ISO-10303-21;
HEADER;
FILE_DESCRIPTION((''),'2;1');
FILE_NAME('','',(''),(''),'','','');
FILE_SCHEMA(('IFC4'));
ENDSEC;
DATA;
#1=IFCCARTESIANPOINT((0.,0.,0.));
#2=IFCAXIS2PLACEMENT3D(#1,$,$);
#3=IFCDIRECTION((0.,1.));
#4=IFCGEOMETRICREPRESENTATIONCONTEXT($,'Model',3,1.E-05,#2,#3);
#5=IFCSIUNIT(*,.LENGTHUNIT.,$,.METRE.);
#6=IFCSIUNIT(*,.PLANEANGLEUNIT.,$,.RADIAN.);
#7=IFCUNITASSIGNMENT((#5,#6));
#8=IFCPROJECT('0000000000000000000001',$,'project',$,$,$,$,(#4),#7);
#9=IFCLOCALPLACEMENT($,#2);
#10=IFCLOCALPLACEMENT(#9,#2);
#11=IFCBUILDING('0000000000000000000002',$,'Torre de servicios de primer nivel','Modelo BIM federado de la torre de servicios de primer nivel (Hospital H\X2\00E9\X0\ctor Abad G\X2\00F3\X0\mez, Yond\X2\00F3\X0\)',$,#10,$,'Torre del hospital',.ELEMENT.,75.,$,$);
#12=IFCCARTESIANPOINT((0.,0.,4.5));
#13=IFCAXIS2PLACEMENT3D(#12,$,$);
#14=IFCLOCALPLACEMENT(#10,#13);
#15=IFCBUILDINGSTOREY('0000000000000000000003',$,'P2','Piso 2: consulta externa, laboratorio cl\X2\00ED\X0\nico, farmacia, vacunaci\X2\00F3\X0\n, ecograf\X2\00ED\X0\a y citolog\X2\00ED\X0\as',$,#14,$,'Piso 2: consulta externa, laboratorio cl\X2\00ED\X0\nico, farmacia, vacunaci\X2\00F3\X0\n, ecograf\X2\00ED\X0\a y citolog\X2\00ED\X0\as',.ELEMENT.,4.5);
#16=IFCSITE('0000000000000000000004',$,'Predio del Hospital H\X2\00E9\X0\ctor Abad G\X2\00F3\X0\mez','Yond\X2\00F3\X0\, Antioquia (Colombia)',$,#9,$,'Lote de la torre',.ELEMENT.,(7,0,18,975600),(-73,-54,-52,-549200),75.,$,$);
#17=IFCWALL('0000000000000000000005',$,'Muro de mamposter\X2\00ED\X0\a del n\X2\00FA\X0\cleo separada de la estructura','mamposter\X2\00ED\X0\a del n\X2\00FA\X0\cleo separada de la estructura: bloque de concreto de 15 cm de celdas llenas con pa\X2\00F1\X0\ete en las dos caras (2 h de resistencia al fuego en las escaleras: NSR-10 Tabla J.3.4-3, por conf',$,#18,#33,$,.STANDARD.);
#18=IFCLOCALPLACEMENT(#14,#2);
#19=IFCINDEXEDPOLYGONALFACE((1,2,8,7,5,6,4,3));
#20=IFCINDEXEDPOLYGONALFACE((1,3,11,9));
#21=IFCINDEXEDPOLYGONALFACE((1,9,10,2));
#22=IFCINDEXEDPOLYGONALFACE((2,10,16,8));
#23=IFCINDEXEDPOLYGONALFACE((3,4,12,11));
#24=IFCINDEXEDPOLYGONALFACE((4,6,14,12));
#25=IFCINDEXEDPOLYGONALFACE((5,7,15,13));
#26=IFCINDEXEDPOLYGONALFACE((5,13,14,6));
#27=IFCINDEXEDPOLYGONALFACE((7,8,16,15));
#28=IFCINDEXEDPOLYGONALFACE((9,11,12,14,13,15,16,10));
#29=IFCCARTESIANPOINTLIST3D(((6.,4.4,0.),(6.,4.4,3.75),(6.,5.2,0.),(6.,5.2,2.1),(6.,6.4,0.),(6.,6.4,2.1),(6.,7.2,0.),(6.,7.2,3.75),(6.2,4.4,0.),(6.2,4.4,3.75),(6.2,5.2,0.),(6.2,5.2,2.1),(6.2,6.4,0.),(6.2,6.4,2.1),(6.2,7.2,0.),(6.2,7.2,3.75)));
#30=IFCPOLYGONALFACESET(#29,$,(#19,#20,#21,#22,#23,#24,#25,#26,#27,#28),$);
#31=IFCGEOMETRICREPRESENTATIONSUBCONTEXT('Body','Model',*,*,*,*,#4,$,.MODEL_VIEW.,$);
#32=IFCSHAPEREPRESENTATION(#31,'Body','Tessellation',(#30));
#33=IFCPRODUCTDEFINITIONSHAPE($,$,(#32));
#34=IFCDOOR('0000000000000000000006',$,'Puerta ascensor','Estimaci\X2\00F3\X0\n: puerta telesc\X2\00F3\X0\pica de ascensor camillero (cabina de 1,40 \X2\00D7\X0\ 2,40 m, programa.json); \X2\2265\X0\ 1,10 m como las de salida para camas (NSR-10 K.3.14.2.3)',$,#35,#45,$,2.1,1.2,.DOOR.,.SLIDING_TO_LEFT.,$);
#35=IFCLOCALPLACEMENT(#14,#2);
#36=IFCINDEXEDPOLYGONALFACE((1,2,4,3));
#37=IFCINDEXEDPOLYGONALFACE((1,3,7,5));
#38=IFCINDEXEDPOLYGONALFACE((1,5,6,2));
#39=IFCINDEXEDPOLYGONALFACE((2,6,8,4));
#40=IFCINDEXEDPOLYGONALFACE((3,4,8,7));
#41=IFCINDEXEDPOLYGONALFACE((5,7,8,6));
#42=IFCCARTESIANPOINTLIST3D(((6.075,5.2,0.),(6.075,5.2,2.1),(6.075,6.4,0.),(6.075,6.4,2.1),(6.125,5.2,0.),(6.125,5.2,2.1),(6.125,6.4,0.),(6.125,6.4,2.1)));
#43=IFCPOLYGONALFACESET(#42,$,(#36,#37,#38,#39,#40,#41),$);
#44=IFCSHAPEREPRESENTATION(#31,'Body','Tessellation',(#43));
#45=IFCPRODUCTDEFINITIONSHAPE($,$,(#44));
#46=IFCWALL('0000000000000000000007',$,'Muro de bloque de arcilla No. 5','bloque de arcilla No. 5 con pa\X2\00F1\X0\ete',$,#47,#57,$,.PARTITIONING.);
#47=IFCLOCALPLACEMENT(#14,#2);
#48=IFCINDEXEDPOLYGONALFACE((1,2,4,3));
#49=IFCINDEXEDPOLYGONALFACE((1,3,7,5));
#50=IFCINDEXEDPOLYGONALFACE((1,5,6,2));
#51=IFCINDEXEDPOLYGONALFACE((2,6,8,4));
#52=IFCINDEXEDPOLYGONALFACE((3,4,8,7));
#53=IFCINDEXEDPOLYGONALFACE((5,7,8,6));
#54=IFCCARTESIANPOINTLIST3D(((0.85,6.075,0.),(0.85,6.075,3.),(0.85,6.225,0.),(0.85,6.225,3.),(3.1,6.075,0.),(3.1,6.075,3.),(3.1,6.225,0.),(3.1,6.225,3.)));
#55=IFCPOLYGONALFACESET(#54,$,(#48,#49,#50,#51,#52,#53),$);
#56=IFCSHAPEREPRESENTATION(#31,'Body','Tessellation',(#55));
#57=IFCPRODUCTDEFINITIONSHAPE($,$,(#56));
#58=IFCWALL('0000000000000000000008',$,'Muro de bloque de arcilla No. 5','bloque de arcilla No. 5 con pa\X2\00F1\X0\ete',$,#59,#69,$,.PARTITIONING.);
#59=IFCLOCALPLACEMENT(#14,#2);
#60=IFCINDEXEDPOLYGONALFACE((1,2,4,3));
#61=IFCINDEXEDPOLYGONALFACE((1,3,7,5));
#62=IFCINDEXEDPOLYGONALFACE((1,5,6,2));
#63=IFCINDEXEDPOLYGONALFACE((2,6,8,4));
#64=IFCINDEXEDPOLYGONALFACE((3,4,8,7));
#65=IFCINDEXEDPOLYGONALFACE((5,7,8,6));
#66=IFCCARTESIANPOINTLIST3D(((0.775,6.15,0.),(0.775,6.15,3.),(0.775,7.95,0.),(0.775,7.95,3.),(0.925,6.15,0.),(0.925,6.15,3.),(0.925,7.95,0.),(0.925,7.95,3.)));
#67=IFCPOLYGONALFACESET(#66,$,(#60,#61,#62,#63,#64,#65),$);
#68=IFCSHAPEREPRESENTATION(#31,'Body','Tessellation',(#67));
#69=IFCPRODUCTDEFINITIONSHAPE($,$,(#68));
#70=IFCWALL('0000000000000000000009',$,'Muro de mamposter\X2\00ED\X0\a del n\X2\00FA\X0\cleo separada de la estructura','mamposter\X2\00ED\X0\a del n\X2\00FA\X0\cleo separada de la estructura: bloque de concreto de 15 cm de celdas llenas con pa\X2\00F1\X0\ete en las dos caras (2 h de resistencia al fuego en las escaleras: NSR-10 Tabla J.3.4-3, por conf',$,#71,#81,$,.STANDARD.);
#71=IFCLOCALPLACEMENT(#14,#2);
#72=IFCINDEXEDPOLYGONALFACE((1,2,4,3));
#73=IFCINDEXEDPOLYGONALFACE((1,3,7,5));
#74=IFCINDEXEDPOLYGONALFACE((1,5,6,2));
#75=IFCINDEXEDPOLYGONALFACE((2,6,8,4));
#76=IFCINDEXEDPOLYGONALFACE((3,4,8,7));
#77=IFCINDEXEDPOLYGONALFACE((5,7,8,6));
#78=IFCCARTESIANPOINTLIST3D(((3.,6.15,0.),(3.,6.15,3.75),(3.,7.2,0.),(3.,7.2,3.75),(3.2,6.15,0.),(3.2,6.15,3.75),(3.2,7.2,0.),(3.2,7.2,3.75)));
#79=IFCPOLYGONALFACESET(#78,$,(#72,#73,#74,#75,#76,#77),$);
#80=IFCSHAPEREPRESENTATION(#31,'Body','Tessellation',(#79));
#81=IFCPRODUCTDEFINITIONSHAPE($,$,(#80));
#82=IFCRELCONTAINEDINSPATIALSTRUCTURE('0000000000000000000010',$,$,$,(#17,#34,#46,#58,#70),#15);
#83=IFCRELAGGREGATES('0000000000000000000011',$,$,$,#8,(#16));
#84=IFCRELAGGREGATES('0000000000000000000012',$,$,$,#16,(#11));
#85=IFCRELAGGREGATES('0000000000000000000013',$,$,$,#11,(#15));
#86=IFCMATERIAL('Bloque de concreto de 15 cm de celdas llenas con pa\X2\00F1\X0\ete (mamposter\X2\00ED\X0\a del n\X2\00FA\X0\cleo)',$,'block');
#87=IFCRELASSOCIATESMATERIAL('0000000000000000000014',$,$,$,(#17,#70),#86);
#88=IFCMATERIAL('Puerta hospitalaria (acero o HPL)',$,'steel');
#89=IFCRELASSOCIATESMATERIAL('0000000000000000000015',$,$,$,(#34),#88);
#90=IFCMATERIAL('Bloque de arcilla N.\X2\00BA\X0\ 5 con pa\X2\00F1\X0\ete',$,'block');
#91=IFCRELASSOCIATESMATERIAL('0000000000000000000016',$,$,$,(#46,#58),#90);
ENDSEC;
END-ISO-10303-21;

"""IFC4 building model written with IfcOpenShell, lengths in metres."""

from ifc_helpers import new_model, si_unit, direction, frame, origin, place, context, subcontext, project, spatial, rectangle, extrude, material, element, fill, save


model = new_model("IFC4")

# Units and contexts
model_context = context("Model", 3, precision=1e-05, world=origin(), true_north=direction((0.0, 1.0)))
body_context = subcontext(model_context, "Body", "Model", "MODEL_VIEW")
ifc_project = project(units=[si_unit("LENGTHUNIT", "METRE"), si_unit("PLANEANGLEUNIT", "RADIAN")], contexts=[model_context])

# Site, building, storey
site_placement = place(None, origin())
site = spatial("IfcSite", under=ifc_project, at=site_placement, Name="Predio del Hospital Héctor Abad Gómez", Description="Yondó, Antioquia (Colombia)", LongName="Lote de la torre", CompositionType="ELEMENT", RefLatitude=(7, 0, 18, 975600), RefLongitude=(-73, -54, -52, -549200), RefElevation=75.0)
building_placement = place(site_placement, origin())
building = spatial("IfcBuilding", under=site, at=building_placement, Name="Torre de servicios de primer nivel", Description="Modelo BIM federado de la torre de servicios de primer nivel (Hospital Héctor Abad Gómez, Yondó)", LongName="Torre del hospital", CompositionType="ELEMENT", ElevationOfRefHeight=75.0)
placement = place(building_placement, frame((0.0, 0.0, 4.5)))
storey = spatial("IfcBuildingStorey", under=building, at=placement, Name="P2", Description="Piso 2: consulta externa, laboratorio clínico, farmacia, vacunación, ecografía y citologías", LongName="Piso 2: consulta externa, laboratorio clínico, farmacia, vacunación, ecografía y citologías", CompositionType="ELEMENT", Elevation=4.5)

# Shared definitions
ifc_material_1 = material(Name="Bloque de arcilla N.º 5 con pañete", Category="block")
ifc_material_2 = material(Name="Puerta hospitalaria (acero o HPL)", Category="steel")

# Shared definitions
ifc_material_3 = material(Name="Bloque de concreto de 15 cm de celdas llenas con pañete (mampostería del núcleo)", Category="block")

# Wall, opening, door
wall_1 = element("IfcWall", 1, at=placement, inside=storey, material=ifc_material_3, Name="Muro de mampostería del núcleo separada de la estructura", Description="mampostería del núcleo separada de la estructura: bloque de concreto de 15 cm de celdas llenas con pañete en las dos caras (2 h de resistencia al fuego en las escaleras: NSR-10 Tabla J.3.4-3, por conf", PredefinedType="STANDARD", context=body_context, shape_type="SweptSolid", body=[
    extrude(rectangle(XDim=0.2, YDim=2.8), frame((6.1, 5.8, 0.0)), (0.0, 0.0, 1.0), 3.75),
])
opening_1 = element("IfcOpeningElement", 2, at=placement, cuts=wall_1, PredefinedType="OPENING", context=body_context, shape_type="SweptSolid", body=[
    extrude(rectangle(XDim=0.3, YDim=1.2), frame((6.1, 5.8, 0.0)), (0.0, 0.0, 1.0), 2.1),
])
door_1 = element("IfcDoor", 3, at=placement, inside=storey, material=ifc_material_2, Name="Puerta ascensor", Description="Estimación: puerta telescópica de ascensor camillero (cabina de 1,40 × 2,40 m, programa.json); ≥ 1,10 m como las de salida para camas (NSR-10 K.3.14.2.3)", OperationType="SLIDING_TO_LEFT", OverallHeight=2.1, OverallWidth=1.2, PredefinedType="DOOR", context=body_context, shape_type="SweptSolid", body=[
    extrude(rectangle(XDim=0.05, YDim=1.2), frame((6.1, 5.8, 0.0)), (0.0, 0.0, 1.0), 2.1),
])
fill(opening_1, door_1)

# Walls
element("IfcWall", 4, at=placement, inside=storey, material=ifc_material_1, Name="Muro de bloque de arcilla No. 5", Description="bloque de arcilla No. 5 con pañete", PredefinedType="PARTITIONING", context=body_context, shape_type="SweptSolid", body=[
    extrude(rectangle(XDim=2.25, YDim=0.15), frame((1.975, 6.15, 0.0)), (0.0, 0.0, 1.0), 3.0),
])
element("IfcWall", 5, at=placement, inside=storey, material=ifc_material_1, Name="Muro de bloque de arcilla No. 5", Description="bloque de arcilla No. 5 con pañete", PredefinedType="PARTITIONING", context=body_context, shape_type="SweptSolid", body=[
    extrude(rectangle(XDim=0.15, YDim=1.8), frame((0.85, 7.05, 0.0)), (0.0, 0.0, 1.0), 3.0),
])
element("IfcWall", 6, at=placement, inside=storey, material=ifc_material_3, Name="Muro de mampostería del núcleo separada de la estructura", Description="mampostería del núcleo separada de la estructura: bloque de concreto de 15 cm de celdas llenas con pañete en las dos caras (2 h de resistencia al fuego en las escaleras: NSR-10 Tabla J.3.4-3, por conf", PredefinedType="STANDARD", context=body_context, shape_type="SweptSolid", body=[
    extrude(rectangle(XDim=0.2, YDim=1.05), frame((3.1, 6.675, 0.0)), (0.0, 0.0, 1.0), 3.75),
])

save(model, "model.ifc")
